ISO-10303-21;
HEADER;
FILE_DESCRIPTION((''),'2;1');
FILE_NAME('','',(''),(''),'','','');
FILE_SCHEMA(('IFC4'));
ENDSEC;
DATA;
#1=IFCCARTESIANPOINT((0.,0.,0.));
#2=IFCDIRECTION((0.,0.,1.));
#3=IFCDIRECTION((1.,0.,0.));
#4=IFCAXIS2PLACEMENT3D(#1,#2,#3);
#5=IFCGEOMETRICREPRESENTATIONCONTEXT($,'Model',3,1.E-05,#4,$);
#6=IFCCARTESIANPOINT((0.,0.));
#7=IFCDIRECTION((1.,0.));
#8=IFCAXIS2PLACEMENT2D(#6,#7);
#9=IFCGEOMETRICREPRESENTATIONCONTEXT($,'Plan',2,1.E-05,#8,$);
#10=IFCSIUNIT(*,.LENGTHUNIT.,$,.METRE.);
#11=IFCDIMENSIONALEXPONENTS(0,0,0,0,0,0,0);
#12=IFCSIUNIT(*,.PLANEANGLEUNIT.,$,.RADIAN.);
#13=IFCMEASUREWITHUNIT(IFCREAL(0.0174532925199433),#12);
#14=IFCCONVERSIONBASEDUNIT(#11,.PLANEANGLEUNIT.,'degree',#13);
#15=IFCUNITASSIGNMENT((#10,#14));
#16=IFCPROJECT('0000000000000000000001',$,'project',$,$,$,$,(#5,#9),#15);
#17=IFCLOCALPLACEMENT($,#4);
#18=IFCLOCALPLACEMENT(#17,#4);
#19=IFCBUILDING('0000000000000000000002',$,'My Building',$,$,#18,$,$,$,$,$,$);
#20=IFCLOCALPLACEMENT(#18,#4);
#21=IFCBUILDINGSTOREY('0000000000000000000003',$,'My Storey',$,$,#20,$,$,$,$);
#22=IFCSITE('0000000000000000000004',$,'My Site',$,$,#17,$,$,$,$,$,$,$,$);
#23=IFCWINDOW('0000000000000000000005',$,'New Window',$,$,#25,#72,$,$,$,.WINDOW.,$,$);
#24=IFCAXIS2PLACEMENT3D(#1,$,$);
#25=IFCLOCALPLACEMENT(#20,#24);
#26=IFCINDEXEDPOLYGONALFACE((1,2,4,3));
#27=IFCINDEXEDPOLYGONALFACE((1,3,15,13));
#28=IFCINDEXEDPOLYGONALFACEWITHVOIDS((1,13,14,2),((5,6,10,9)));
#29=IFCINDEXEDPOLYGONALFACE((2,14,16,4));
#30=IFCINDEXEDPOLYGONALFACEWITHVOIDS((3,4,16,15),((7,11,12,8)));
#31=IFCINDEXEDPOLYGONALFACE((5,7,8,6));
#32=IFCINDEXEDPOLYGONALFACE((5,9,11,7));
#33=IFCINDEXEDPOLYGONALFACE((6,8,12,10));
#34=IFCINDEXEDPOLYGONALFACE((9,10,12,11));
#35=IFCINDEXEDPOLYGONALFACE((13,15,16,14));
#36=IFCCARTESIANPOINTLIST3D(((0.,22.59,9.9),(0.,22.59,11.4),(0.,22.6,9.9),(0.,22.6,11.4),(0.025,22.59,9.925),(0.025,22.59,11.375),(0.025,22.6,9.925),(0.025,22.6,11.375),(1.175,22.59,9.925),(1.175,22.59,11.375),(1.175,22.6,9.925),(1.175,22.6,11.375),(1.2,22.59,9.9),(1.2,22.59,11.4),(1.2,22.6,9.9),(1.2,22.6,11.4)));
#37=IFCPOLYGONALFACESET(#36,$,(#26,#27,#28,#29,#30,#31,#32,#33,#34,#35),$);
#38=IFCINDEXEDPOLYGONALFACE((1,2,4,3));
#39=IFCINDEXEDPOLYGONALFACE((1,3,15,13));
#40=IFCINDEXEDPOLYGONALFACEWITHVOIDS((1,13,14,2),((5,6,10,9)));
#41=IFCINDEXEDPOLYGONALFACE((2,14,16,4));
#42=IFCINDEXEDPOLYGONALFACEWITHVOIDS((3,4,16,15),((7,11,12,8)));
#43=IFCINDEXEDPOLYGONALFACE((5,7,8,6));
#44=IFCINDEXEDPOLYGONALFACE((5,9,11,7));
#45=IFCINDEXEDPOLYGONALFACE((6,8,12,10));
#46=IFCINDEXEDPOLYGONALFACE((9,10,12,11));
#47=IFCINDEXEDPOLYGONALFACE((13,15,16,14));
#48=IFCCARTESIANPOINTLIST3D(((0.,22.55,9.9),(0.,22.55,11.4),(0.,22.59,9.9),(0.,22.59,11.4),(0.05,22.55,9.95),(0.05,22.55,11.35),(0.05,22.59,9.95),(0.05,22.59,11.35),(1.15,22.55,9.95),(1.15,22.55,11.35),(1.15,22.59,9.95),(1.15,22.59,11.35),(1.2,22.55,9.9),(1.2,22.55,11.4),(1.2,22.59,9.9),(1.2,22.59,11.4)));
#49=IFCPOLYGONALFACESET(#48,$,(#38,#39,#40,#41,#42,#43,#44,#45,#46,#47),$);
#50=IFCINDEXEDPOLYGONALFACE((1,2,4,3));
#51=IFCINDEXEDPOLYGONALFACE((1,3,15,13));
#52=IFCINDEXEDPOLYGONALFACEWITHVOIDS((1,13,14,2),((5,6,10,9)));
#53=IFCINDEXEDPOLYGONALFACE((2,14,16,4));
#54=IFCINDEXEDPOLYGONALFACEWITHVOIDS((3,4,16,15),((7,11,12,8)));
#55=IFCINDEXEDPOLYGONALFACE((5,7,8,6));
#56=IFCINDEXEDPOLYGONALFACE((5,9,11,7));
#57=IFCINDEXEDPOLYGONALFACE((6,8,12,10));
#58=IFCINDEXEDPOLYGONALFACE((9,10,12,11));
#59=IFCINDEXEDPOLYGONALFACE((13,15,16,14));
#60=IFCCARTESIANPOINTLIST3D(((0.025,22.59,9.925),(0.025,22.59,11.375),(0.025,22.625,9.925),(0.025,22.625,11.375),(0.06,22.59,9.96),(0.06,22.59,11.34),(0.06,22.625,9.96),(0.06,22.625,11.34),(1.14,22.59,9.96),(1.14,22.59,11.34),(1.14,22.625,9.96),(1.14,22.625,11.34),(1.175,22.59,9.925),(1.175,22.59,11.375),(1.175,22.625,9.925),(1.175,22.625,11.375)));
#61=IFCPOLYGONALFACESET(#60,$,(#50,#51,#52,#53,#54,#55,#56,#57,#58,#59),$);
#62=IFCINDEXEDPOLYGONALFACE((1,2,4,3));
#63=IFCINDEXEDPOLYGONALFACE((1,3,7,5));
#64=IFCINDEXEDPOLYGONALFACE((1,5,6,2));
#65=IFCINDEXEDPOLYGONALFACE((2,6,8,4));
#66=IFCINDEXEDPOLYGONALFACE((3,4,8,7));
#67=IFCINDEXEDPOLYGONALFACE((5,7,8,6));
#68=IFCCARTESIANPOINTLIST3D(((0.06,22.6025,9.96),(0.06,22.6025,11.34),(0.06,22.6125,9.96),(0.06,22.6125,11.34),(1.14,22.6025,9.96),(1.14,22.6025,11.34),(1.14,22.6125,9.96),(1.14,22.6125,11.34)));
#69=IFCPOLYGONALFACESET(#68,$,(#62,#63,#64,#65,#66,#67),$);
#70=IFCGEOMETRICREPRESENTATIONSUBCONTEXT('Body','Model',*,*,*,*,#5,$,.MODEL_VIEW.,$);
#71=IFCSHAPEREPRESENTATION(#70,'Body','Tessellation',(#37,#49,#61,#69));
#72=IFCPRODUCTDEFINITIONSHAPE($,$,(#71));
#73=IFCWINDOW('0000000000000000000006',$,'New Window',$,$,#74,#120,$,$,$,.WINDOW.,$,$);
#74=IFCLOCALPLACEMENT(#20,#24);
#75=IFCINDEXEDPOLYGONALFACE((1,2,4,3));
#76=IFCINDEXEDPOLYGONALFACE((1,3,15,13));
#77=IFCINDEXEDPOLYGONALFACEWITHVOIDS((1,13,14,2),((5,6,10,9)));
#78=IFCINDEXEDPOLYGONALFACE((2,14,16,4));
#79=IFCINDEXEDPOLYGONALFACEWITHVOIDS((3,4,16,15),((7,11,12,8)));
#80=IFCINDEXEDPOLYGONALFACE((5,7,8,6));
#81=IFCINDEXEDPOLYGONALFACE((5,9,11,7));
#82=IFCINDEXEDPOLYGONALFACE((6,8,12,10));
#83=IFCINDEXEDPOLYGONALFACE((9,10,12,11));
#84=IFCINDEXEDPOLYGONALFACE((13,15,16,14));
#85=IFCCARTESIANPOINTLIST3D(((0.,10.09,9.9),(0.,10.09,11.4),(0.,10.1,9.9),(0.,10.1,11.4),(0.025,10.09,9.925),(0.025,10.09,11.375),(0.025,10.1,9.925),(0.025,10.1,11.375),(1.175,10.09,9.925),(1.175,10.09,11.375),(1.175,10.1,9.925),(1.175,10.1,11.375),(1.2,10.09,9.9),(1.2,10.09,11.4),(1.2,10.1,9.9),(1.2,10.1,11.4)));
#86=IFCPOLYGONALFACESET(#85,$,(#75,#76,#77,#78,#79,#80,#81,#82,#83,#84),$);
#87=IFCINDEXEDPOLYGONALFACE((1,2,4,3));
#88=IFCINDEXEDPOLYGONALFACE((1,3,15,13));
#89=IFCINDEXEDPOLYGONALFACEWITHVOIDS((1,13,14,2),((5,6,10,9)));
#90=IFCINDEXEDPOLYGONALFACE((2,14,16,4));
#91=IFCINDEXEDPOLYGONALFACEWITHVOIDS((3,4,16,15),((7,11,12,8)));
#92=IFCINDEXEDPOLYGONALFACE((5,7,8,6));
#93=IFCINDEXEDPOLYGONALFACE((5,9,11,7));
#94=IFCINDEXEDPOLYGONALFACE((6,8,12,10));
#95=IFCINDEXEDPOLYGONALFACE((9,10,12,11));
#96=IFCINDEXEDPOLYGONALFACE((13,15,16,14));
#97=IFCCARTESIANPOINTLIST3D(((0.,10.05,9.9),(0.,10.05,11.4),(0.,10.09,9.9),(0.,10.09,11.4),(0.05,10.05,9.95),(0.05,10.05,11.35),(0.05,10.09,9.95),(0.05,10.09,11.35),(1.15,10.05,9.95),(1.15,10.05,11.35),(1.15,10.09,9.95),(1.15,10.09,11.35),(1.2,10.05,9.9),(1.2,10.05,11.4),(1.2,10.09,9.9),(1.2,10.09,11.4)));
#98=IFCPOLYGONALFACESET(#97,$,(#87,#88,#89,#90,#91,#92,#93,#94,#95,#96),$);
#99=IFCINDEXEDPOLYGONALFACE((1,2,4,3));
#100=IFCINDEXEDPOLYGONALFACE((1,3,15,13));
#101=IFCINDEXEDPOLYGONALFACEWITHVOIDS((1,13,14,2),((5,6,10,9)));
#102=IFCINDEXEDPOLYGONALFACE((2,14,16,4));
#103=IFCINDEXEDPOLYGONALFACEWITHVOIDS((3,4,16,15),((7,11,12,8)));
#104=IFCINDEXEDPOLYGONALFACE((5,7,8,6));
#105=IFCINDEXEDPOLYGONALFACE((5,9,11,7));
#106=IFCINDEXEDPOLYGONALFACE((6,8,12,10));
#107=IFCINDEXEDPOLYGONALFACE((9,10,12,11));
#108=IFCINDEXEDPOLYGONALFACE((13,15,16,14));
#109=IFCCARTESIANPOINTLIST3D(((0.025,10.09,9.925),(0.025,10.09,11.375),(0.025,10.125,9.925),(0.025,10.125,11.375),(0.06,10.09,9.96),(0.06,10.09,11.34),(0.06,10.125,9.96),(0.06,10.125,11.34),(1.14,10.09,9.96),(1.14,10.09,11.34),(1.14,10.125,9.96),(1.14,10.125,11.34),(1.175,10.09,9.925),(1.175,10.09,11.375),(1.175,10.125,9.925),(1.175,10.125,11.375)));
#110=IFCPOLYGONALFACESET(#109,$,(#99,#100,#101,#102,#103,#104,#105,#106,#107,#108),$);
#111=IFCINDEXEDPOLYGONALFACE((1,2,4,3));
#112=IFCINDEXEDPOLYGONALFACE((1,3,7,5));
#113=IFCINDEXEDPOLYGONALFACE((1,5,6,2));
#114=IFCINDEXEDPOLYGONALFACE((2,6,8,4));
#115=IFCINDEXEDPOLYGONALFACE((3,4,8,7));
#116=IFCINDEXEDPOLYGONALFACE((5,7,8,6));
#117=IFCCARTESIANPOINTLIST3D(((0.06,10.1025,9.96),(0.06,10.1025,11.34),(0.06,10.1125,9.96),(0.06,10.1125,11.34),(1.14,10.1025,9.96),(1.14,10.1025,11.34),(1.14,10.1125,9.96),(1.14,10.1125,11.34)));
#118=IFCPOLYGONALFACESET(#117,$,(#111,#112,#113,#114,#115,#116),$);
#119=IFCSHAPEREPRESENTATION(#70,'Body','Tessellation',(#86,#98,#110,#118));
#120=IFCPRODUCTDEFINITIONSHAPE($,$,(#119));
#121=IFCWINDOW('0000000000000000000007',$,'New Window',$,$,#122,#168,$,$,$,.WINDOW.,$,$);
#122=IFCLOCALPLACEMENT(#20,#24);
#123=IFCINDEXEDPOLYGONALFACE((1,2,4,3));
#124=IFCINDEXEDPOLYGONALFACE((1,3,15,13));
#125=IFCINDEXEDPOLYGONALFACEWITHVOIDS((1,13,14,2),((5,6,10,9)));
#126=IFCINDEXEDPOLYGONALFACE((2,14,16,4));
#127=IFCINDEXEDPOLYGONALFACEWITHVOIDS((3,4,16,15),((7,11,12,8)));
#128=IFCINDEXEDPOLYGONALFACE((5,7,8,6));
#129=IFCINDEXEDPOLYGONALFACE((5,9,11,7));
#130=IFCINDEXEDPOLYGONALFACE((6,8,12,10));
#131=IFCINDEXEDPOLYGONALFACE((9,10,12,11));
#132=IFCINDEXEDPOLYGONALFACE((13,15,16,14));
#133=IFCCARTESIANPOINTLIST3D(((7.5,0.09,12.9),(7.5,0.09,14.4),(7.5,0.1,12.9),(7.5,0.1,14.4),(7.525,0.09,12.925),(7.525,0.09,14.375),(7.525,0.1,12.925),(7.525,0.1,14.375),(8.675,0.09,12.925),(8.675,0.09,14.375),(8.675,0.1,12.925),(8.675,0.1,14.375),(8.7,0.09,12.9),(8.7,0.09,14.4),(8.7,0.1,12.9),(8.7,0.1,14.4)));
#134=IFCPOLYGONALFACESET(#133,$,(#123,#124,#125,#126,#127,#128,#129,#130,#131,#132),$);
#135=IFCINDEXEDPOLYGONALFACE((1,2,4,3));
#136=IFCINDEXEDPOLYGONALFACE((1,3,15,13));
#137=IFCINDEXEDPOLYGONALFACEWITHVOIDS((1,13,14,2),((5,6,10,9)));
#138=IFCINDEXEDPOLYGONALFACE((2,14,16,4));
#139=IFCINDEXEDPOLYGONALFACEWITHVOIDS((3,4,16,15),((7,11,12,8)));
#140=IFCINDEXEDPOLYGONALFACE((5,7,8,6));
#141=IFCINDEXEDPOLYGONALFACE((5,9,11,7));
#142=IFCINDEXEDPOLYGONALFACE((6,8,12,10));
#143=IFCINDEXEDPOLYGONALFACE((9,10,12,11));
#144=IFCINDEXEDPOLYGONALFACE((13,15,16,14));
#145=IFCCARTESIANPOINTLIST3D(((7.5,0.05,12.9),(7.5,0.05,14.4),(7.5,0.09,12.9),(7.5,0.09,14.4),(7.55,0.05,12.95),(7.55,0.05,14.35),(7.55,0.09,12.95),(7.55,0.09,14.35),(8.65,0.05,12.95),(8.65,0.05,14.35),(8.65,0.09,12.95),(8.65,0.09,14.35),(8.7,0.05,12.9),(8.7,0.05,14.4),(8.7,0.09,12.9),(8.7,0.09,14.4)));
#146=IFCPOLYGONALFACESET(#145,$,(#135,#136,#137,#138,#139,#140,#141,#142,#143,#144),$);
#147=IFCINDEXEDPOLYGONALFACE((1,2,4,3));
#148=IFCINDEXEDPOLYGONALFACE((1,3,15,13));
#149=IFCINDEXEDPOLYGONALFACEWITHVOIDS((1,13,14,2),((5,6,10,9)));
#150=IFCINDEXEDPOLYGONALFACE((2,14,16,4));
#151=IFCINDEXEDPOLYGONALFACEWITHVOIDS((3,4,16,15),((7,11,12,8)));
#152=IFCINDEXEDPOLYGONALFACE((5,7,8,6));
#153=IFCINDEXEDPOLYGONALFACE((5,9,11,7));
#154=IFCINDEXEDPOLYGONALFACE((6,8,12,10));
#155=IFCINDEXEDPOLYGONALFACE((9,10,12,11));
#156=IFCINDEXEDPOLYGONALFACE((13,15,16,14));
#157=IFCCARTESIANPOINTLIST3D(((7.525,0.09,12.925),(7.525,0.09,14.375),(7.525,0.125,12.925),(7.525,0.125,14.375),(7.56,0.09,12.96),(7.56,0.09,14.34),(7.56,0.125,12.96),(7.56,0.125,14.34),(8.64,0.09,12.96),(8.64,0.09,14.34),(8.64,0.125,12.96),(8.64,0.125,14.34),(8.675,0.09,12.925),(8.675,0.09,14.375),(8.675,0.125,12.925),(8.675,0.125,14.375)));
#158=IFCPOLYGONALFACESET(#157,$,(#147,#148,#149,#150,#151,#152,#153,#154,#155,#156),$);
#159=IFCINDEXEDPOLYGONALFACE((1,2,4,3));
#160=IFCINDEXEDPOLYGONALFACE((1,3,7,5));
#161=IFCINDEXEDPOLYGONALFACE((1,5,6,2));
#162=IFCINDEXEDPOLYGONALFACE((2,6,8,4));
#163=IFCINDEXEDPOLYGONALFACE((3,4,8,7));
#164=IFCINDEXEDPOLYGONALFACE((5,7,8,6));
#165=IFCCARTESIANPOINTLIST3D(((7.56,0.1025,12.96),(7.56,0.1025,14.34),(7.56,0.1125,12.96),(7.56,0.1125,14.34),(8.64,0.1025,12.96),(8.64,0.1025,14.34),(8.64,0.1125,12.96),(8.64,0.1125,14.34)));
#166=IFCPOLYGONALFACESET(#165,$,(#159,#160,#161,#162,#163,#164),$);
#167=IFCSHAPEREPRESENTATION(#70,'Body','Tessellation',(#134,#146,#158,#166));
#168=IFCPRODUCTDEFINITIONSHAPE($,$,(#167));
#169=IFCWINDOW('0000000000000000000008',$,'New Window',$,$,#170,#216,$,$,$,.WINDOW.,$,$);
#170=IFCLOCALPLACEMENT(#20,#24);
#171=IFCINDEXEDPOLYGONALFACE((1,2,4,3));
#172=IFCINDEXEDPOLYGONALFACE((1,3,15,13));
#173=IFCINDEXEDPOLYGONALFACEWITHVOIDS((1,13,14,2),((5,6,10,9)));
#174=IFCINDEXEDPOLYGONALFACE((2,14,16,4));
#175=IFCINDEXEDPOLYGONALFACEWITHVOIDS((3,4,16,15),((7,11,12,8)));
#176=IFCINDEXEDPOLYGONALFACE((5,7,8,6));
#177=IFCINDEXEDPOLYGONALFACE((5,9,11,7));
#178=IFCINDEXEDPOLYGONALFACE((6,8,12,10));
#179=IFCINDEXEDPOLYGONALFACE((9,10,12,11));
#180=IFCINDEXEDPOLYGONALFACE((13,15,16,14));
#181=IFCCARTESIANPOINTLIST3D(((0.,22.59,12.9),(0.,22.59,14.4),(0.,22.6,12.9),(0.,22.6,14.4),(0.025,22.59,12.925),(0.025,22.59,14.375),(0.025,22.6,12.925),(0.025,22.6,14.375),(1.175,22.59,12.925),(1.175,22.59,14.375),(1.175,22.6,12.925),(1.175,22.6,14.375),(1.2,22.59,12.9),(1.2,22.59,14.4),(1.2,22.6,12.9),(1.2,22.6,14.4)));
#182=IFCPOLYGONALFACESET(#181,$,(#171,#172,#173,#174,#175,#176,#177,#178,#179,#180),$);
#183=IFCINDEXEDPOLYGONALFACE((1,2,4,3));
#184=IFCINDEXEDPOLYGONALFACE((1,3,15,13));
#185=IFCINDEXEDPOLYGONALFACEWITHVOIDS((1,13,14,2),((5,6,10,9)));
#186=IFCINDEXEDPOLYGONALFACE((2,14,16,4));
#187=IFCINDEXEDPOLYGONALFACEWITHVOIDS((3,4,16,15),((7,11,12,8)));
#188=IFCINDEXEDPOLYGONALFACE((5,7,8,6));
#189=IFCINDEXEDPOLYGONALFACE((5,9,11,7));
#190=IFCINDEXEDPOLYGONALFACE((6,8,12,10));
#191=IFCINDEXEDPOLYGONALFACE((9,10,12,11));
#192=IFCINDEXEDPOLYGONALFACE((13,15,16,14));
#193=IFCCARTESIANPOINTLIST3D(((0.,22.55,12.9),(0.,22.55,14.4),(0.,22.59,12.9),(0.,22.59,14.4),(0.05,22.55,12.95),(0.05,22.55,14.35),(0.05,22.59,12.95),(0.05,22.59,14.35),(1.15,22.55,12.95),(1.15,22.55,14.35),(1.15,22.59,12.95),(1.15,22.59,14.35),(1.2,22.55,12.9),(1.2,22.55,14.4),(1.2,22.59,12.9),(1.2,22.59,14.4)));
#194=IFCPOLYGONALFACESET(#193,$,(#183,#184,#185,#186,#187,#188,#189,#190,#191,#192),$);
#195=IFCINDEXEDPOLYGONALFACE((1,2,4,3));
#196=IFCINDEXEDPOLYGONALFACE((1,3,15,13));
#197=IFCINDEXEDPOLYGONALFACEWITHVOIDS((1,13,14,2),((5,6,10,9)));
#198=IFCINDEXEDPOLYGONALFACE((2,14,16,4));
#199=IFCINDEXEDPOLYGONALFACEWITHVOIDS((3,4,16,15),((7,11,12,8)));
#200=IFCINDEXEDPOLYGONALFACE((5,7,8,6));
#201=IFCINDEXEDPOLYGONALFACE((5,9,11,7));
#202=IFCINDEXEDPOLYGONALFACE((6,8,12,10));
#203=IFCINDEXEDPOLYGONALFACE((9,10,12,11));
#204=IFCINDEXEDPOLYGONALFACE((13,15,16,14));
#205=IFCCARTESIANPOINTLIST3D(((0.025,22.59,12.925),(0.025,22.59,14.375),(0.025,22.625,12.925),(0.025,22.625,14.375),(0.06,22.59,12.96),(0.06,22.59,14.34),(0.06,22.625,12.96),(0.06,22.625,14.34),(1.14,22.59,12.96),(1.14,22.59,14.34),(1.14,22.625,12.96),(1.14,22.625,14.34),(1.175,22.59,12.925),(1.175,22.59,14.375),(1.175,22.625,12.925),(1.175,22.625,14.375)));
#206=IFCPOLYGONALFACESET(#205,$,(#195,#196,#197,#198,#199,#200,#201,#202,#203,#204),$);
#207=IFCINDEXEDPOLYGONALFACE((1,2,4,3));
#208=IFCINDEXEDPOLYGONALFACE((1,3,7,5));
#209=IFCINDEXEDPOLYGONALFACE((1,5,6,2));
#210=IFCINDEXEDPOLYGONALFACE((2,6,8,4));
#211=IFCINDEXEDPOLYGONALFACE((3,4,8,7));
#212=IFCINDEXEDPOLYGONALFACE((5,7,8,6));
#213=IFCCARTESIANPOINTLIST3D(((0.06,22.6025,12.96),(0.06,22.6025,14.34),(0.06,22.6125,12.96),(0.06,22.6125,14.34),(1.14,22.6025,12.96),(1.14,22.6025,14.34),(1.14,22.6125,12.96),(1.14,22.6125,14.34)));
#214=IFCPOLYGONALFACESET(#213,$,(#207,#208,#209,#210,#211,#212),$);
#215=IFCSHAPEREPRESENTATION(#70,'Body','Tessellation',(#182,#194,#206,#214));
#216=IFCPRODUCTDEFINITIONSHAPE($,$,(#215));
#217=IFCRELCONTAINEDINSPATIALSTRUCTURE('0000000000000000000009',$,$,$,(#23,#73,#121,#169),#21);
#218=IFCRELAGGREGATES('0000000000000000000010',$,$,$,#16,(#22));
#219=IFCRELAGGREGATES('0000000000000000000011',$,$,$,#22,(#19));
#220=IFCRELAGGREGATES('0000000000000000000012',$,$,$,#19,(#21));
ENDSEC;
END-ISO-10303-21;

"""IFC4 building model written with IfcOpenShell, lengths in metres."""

from ifc_helpers import new_model, entity, si_unit, converted_unit, frame, origin_with_axes, origin_2d_with_axis, place, context, subcontext, project, spatial, line, indexed_curve, outline, extrude, element, save


model = new_model("IFC4")

# Units and contexts
model_context = context("Model", 3, precision=1e-05, world=origin_with_axes())
plan_context = context("Plan", 2, precision=1e-05, world=origin_2d_with_axis())
body_context = subcontext(model_context, "Body", "Model", "MODEL_VIEW")
ifc_project = project(units=[si_unit("LENGTHUNIT", "METRE"), converted_unit("PLANEANGLEUNIT", "degree", entity("IfcReal", 0.0174532925199433), si_unit("PLANEANGLEUNIT", "RADIAN"), dimensions=[0, 0, 0, 0, 0, 0, 0])], contexts=[model_context, plan_context])

# Site, building, storey
site_placement = place(None, origin_with_axes())
site = spatial("IfcSite", under=ifc_project, at=site_placement, Name="My Site")
building_placement = place(site_placement, origin_with_axes())
building = spatial("IfcBuilding", under=site, at=building_placement, Name="My Building")
storey_placement = place(building_placement, origin_with_axes())
storey = spatial("IfcBuildingStorey", under=building, at=storey_placement, Name="My Storey")

# Windows
for number, where, z_axis, x_axis, name in (
    (1, (0.0, 22.5, 9.9), (0.0, 0.0, 1.0), (1.0, 0.0, 0.0), "New Window"),
    (2, (0.0, 10.0, 9.9), (0.0, 0.0, 1.0), (1.0, 0.0, 0.0), "New Window"),
    (3, (7.5, 0.0, 12.9), (0.0, 0.0, 1.0), (1.0, 0.0, 0.0), "New Window"),
    (4, (0.0, 22.5, 12.9), (0.0, 0.0, 1.0), (1.0, 0.0, 0.0), "New Window"),
):
    element("IfcWindow", number, at=place(storey_placement, frame(where, z_axis=z_axis, x_axis=x_axis)), inside=storey, Name=name, PredefinedType="WINDOW", context=body_context, shape_type="SweptSolid", body=[
        extrude(outline(indexed_curve([(0.0, 0.0), (1.2, 0.0), (1.2, 1.5), (0.0, 1.5)], segments=[line(1, 2, 3, 4, 1)]), holes=[indexed_curve([(0.025, 0.025), (1.175, 0.025), (1.175, 1.475), (0.025, 1.475)], segments=[line(1, 2, 3, 4, 1)])]), frame((0.0, 0.09, 0.0), z_axis=(0.0, -1.0, 0.0), x_axis=(1.0, 0.0, 0.0)), (0.0, 0.0, -1.0), 0.01),
        extrude(outline(indexed_curve([(0.0, 0.0), (1.2, 0.0), (1.2, 1.5), (0.0, 1.5)], segments=[line(1, 2, 3, 4, 1)]), holes=[indexed_curve([(0.05, 0.05), (1.15, 0.05), (1.15, 1.45), (0.05, 1.45)], segments=[line(1, 2, 3, 4, 1)])]), frame((0.0, 0.05, 0.0), z_axis=(0.0, -1.0, 0.0), x_axis=(1.0, 0.0, 0.0)), (0.0, 0.0, -1.0), 0.04),
        extrude(outline(indexed_curve([(0.0, 0.0), (1.15, 0.0), (1.15, 1.45), (0.0, 1.45)], segments=[line(1, 2, 3, 4, 1)]), holes=[indexed_curve([(0.035, 0.035), (1.115, 0.035), (1.115, 1.415), (0.035, 1.415)], segments=[line(1, 2, 3, 4, 1)])]), frame((0.025, 0.09, 0.025), z_axis=(0.0, -1.0, 0.0), x_axis=(1.0, 0.0, 0.0)), (0.0, 0.0, -1.0), 0.035),
        extrude(outline(indexed_curve([(0.035, 0.035), (1.115, 0.035), (1.115, 1.415), (0.035, 1.415)], segments=[line(1, 2, 3, 4, 1)])), frame((0.025, 0.1025, 0.025), z_axis=(0.0, -1.0, 0.0), x_axis=(1.0, 0.0, 0.0)), (0.0, 0.0, -1.0), 0.01),
    ])

save(model, "model.ifc")
